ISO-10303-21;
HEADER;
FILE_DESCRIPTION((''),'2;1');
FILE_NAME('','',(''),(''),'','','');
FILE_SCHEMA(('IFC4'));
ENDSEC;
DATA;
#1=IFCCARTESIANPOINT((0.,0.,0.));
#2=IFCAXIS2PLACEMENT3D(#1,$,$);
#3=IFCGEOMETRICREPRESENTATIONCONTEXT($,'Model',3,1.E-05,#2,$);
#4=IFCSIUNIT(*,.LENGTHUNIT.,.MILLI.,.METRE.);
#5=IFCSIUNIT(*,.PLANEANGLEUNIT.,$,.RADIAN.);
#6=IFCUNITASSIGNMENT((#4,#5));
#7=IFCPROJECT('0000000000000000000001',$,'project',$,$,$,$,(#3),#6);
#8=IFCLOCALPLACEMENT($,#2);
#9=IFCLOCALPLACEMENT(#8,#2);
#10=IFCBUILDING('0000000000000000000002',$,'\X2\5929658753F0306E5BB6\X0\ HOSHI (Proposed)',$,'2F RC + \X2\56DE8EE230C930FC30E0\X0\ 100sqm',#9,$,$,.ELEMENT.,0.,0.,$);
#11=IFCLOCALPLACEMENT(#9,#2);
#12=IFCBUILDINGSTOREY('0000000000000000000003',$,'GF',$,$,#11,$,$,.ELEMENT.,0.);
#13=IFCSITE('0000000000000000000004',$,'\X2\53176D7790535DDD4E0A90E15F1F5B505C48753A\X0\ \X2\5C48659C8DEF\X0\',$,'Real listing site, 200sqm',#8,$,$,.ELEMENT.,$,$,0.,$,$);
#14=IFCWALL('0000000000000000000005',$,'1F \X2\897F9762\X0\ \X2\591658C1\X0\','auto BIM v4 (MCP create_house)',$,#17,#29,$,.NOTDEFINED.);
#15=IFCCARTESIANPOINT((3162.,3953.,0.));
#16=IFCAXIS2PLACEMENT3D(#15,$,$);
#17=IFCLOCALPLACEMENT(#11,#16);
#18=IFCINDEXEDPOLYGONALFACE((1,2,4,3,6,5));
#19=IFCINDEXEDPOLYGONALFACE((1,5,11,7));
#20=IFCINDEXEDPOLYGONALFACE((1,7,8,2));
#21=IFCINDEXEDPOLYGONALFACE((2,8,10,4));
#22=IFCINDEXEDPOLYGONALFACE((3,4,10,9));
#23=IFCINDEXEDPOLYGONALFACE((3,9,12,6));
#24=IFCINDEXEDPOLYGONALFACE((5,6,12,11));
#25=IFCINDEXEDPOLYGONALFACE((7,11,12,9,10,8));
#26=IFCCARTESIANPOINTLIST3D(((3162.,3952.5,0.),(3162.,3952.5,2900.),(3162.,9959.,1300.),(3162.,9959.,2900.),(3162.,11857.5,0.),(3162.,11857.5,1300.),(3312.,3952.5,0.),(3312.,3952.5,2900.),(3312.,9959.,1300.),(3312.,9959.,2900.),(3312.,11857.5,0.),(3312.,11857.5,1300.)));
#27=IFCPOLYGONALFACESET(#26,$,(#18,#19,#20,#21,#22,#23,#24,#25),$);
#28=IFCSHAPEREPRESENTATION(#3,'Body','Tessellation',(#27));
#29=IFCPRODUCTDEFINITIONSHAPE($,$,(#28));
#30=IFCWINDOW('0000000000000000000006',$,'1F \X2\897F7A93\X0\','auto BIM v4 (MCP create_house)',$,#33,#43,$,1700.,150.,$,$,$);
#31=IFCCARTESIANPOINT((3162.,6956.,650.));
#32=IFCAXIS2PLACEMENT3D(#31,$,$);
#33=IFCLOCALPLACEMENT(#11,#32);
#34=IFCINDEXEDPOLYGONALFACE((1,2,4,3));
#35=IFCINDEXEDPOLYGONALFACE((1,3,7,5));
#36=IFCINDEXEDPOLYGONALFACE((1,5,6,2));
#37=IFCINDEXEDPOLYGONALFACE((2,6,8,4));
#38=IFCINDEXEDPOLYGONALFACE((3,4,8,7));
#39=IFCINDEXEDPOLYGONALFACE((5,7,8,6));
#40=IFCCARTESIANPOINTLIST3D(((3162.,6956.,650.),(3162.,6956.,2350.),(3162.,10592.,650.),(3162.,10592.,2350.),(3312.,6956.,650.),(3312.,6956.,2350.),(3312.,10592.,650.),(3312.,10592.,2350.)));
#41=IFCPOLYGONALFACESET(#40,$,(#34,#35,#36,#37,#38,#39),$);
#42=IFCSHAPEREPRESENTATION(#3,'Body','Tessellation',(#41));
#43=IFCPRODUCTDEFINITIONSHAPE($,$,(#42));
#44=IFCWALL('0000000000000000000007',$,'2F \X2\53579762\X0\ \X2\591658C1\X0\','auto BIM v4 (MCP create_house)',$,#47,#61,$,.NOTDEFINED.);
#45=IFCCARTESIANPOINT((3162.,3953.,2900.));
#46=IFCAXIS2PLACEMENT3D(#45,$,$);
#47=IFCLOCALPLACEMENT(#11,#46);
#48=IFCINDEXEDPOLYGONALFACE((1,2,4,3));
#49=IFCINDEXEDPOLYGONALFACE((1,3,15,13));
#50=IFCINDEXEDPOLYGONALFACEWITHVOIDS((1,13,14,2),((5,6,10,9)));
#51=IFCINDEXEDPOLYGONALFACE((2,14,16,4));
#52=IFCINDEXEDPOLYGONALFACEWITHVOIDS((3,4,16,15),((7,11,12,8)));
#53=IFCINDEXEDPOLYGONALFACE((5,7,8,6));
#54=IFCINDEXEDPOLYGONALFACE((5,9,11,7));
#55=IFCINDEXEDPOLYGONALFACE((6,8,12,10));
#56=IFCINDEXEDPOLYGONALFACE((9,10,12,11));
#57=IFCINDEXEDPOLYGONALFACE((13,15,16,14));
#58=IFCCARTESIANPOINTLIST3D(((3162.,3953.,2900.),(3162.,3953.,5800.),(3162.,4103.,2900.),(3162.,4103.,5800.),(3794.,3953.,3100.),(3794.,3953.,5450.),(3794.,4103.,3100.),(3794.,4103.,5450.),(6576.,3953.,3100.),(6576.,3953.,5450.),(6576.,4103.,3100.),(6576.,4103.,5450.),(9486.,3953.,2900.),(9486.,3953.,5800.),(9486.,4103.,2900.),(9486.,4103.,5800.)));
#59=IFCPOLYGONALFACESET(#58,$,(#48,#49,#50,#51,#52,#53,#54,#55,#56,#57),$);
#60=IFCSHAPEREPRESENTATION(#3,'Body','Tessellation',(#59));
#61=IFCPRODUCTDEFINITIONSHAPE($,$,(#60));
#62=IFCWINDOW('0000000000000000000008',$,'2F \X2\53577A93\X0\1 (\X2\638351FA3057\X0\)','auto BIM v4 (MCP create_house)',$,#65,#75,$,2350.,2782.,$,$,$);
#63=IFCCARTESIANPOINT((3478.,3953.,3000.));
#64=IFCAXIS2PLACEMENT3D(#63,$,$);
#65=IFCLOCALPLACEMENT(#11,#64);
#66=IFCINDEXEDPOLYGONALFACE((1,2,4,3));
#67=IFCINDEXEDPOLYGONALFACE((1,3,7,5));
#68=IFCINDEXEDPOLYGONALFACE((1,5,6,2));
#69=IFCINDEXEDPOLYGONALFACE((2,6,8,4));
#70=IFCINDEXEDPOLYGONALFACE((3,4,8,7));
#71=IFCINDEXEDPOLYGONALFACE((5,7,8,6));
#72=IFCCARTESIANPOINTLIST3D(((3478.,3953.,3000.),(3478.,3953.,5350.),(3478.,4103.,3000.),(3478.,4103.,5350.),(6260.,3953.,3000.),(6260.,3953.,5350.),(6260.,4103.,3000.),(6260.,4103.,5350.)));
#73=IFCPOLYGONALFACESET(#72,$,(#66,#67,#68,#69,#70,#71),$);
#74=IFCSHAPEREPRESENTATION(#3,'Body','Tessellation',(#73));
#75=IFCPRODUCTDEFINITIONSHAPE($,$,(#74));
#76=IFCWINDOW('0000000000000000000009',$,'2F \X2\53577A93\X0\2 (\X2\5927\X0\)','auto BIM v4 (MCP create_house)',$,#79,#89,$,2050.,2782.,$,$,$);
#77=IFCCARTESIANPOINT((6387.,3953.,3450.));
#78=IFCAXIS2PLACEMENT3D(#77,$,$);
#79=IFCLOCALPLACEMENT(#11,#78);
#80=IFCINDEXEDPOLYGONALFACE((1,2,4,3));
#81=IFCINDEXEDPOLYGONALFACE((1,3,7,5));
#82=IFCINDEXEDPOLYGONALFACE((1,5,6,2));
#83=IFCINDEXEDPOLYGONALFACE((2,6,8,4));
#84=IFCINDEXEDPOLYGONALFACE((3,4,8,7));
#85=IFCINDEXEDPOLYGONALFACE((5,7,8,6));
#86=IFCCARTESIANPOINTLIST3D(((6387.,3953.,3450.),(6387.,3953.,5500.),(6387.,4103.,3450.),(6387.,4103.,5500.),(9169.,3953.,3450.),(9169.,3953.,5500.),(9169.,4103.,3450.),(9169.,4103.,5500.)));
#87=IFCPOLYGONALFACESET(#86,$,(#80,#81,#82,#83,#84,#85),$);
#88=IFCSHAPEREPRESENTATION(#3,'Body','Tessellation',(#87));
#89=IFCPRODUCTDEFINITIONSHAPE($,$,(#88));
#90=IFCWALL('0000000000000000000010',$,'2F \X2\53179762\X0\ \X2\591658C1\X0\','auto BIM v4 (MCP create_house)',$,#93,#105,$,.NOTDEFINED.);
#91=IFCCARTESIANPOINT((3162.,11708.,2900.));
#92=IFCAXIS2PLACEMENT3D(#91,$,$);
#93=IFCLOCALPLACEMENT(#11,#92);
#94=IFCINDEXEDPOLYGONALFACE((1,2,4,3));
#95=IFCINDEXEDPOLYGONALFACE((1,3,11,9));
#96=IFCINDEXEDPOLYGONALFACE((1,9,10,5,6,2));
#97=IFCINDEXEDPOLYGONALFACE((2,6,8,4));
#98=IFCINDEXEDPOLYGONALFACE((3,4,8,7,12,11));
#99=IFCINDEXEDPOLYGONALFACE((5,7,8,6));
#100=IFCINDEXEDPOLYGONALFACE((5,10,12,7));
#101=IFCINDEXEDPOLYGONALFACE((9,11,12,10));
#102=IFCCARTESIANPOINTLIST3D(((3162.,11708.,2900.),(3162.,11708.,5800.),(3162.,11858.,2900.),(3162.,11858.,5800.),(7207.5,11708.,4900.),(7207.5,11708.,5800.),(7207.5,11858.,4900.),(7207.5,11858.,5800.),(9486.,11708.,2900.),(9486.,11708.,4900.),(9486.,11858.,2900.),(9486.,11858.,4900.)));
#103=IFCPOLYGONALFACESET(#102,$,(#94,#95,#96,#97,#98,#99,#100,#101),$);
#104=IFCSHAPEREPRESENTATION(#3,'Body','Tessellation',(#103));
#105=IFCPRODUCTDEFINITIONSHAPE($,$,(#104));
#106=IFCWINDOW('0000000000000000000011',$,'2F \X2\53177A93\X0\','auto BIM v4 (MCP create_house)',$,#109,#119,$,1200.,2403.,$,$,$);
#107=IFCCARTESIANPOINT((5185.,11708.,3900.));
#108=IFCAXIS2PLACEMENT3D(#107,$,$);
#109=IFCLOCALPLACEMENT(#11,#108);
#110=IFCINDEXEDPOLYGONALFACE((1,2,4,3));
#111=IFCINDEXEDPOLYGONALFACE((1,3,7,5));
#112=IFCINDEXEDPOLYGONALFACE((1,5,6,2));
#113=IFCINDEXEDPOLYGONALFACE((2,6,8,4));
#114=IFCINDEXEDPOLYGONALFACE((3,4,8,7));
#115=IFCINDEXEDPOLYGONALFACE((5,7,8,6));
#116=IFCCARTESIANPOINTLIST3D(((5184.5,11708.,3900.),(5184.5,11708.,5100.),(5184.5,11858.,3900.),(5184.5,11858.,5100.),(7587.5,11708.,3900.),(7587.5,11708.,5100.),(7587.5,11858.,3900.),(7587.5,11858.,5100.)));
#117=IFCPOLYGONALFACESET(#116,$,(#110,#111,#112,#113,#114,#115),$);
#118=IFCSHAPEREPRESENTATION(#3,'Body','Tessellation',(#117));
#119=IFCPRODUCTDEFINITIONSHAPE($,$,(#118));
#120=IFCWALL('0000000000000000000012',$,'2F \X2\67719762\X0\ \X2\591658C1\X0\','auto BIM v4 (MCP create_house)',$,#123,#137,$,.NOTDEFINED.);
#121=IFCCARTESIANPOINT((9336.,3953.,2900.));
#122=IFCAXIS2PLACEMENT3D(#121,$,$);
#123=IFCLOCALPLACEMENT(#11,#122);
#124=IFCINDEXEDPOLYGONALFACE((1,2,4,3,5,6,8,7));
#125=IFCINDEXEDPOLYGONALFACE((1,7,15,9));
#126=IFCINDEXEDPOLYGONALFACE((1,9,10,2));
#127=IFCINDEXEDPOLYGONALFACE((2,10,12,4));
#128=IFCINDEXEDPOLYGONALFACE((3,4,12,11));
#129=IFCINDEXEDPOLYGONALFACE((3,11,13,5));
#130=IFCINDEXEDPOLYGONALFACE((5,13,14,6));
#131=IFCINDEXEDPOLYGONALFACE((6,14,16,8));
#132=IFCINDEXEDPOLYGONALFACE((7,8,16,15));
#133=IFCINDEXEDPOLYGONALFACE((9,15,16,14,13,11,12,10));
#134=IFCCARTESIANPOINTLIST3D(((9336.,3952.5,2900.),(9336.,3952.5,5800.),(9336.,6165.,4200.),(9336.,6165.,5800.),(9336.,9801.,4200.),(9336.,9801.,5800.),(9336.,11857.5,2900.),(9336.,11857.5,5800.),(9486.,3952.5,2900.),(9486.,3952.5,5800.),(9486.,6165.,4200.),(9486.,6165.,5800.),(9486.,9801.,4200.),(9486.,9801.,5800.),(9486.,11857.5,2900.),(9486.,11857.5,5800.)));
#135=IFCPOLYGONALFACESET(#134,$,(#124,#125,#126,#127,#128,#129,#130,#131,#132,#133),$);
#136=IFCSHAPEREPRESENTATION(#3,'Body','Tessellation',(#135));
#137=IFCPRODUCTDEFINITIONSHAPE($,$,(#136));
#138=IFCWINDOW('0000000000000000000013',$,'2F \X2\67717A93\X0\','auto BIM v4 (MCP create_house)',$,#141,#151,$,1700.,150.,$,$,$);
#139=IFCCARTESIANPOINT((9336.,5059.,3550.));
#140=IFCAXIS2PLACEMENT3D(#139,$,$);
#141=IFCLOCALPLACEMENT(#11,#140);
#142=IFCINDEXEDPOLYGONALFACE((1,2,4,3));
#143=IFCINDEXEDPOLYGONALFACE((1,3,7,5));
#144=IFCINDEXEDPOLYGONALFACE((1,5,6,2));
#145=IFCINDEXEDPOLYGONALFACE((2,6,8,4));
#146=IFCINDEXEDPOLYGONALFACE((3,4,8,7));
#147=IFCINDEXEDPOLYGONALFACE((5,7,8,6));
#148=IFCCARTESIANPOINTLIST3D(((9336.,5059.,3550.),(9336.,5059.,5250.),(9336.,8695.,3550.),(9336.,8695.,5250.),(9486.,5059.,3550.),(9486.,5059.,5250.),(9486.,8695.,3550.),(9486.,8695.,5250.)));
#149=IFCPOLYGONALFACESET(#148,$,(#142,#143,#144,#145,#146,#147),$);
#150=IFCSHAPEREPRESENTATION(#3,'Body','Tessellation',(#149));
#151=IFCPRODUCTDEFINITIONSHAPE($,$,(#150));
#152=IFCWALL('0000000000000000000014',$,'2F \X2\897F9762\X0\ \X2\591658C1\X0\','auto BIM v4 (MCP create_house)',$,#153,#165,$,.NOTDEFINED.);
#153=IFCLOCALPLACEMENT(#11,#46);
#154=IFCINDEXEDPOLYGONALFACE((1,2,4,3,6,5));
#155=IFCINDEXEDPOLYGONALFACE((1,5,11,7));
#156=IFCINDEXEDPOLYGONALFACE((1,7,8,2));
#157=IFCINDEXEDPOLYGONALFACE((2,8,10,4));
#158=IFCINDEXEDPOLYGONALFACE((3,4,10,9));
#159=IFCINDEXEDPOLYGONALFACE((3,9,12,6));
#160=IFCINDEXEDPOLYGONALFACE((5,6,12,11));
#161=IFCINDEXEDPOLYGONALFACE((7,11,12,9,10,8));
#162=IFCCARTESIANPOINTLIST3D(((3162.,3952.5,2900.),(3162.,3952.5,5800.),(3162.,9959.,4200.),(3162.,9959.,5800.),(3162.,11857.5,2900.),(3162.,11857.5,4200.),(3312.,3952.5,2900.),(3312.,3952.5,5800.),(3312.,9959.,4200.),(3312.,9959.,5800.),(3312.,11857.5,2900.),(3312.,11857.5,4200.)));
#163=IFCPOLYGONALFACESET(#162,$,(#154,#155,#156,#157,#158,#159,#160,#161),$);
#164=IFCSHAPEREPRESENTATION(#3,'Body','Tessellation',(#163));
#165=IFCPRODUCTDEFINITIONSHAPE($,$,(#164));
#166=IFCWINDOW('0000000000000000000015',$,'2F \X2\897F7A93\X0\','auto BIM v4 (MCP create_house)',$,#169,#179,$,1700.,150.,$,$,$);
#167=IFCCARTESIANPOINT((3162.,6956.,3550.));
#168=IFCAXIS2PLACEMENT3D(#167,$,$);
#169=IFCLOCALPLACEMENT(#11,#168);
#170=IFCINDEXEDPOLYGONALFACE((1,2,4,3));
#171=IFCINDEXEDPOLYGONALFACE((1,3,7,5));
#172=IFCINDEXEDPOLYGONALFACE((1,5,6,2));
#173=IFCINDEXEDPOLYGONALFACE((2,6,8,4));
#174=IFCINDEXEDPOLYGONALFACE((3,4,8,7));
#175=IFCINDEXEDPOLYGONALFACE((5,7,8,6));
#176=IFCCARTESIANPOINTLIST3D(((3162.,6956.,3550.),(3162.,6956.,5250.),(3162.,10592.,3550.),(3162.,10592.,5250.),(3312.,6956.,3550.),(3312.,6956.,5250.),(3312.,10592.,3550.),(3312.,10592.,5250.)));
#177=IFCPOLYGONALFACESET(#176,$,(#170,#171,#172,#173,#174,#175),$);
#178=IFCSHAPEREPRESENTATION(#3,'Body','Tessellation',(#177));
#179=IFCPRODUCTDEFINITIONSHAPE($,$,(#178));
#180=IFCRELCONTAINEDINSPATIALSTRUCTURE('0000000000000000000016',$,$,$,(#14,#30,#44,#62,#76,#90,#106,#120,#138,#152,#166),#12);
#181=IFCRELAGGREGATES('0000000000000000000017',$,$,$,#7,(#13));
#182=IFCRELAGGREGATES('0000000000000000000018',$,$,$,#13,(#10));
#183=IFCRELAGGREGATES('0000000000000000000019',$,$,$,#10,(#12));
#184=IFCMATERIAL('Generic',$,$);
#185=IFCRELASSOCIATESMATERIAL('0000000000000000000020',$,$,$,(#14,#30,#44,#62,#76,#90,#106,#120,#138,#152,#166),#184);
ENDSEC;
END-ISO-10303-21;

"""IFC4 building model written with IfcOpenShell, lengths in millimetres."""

from ifc_helpers import new_model, si_unit, frame, frame_2d, origin, place, context, project, spatial, rectangle, extrude, material, element, fill, save


model = new_model("IFC4")

# Units and contexts
model_context = context("Model", 3, precision=1e-05, world=origin())
ifc_project = project(units=[si_unit("LENGTHUNIT", "METRE", prefix="MILLI"), si_unit("PLANEANGLEUNIT", "RADIAN")], contexts=[model_context])

# Site, building, storey
site_placement = place(None, origin())
site = spatial("IfcSite", under=ifc_project, at=site_placement, Name="北海道川上郡弟子屈町 屈斜路", ObjectType="Real listing site, 200sqm", CompositionType="ELEMENT", RefElevation=0.0)
building_placement = place(site_placement, origin())
building = spatial("IfcBuilding", under=site, at=building_placement, Name="天文台の家 HOSHI (Proposed)", ObjectType="2F RC + 回転ドーム 100sqm", CompositionType="ELEMENT", ElevationOfRefHeight=0.0, ElevationOfTerrain=0.0)
storey_placement = place(building_placement, origin())
storey = spatial("IfcBuildingStorey", under=building, at=storey_placement, Name="GF", CompositionType="ELEMENT", Elevation=0.0)

# Shared definitions
ifc_material = material(Name="Generic")

# Wall, opening, window
wall_1_placement = place(storey_placement, frame((3162.0, 3953.0, 0.0)))
wall_1 = element("IfcWall", 1, at=wall_1_placement, inside=storey, material=ifc_material, Name="1F 西面 外壁", Description="auto BIM v4 (MCP create_house)", PredefinedType="NOTDEFINED", context=model_context, shape_type="SweptSolid", body=[
    extrude(rectangle(XDim=150.0, YDim=7905.0, at=frame_2d((75.0, 3952.0))), frame((3162.0, 3953.0, 0.0)), (0.0, 0.0, 1.0), 2900.0),
])
opening_1_placement = place(storey_placement, frame((3162.0, 6956.0, 650.0)))
opening_1 = element("IfcOpeningElement", 2, at=opening_1_placement, cuts=wall_1, PredefinedType="NOTDEFINED", context=model_context, shape_type="SweptSolid", body=[
    extrude(rectangle(XDim=150.0, YDim=3636.0, at=frame_2d((75.0, 1818.0))), frame((3162.0, 6956.0, 650.0)), (0.0, 0.0, 1.0), 1700.0),
])
window_1_placement = place(storey_placement, frame((3162.0, 6956.0, 650.0)))
window_1 = element("IfcWindow", 3, at=window_1_placement, inside=storey, material=ifc_material, Name="1F 西窓", Description="auto BIM v4 (MCP create_house)", OverallHeight=1700.0, OverallWidth=150.0, context=model_context, shape_type="SweptSolid", body=[
    extrude(rectangle(XDim=150.0, YDim=3636.0, at=frame_2d((75.0, 1818.0))), frame((3162.0, 6956.0, 650.0)), (0.0, 0.0, 1.0), 1700.0),
])
fill(opening_1, window_1)

# Wall, openings, windows
wall_2_placement = place(storey_placement, frame((3162.0, 3953.0, 2900.0)))
wall_2 = element("IfcWall", 4, at=wall_2_placement, inside=storey, material=ifc_material, Name="2F 南面 外壁", Description="auto BIM v4 (MCP create_house)", PredefinedType="NOTDEFINED", context=model_context, shape_type="SweptSolid", body=[
    extrude(rectangle(XDim=6324.0, YDim=150.0, at=frame_2d((3162.0, 75.0))), frame((3162.0, 3953.0, 2900.0)), (0.0, 0.0, 1.0), 2900.0),
])
opening_2_placement = place(storey_placement, frame((3478.0, 3953.0, 3000.0)))
opening_2 = element("IfcOpeningElement", 5, at=opening_2_placement, cuts=wall_2, PredefinedType="NOTDEFINED", context=model_context, shape_type="SweptSolid", body=[
    extrude(rectangle(XDim=2782.0, YDim=150.0, at=frame_2d((1391.0, 75.0))), frame((3478.0, 3953.0, 3000.0)), (0.0, 0.0, 1.0), 2350.0),
])
opening_3_placement = place(storey_placement, frame((6387.0, 3953.0, 3450.0)))
opening_3 = element("IfcOpeningElement", 6, at=opening_3_placement, cuts=wall_2, PredefinedType="NOTDEFINED", context=model_context, shape_type="SweptSolid", body=[
    extrude(rectangle(XDim=2782.0, YDim=150.0, at=frame_2d((1391.0, 75.0))), frame((6387.0, 3953.0, 3450.0)), (0.0, 0.0, 1.0), 2050.0),
])
window_2_placement = place(storey_placement, frame((3478.0, 3953.0, 3000.0)))
window_2 = element("IfcWindow", 7, at=window_2_placement, inside=storey, material=ifc_material, Name="2F 南窓1 (掃出し)", Description="auto BIM v4 (MCP create_house)", OverallHeight=2350.0, OverallWidth=2782.0, context=model_context, shape_type="SweptSolid", body=[
    extrude(rectangle(XDim=2782.0, YDim=150.0, at=frame_2d((1391.0, 75.0))), frame((3478.0, 3953.0, 3000.0)), (0.0, 0.0, 1.0), 2350.0),
])
fill(opening_2, window_2)
window_3_placement = place(storey_placement, frame((6387.0, 3953.0, 3450.0)))
window_3 = element("IfcWindow", 8, at=window_3_placement, inside=storey, material=ifc_material, Name="2F 南窓2 (大)", Description="auto BIM v4 (MCP create_house)", OverallHeight=2050.0, OverallWidth=2782.0, context=model_context, shape_type="SweptSolid", body=[
    extrude(rectangle(XDim=2782.0, YDim=150.0, at=frame_2d((1391.0, 75.0))), frame((6387.0, 3953.0, 3450.0)), (0.0, 0.0, 1.0), 2050.0),
])
fill(opening_3, window_3)

# Walls, openings, windows
wall_3_placement = place(storey_placement, frame((3162.0, 11708.0, 2900.0)))
wall_3 = element("IfcWall", 9, at=wall_3_placement, inside=storey, material=ifc_material, Name="2F 北面 外壁", Description="auto BIM v4 (MCP create_house)", PredefinedType="NOTDEFINED", context=model_context, shape_type="SweptSolid", body=[
    extrude(rectangle(XDim=6324.0, YDim=150.0, at=frame_2d((3162.0, 75.0))), frame((3162.0, 11708.0, 2900.0)), (0.0, 0.0, 1.0), 2900.0),
])
opening_4_placement = place(storey_placement, frame((5185.0, 11708.0, 3900.0)))
opening_4 = element("IfcOpeningElement", 10, at=opening_4_placement, cuts=wall_3, PredefinedType="NOTDEFINED", context=model_context, shape_type="SweptSolid", body=[
    extrude(rectangle(XDim=2403.0, YDim=150.0, at=frame_2d((1201.0, 75.0))), frame((5185.0, 11708.0, 3900.0)), (0.0, 0.0, 1.0), 1200.0),
])
window_4_placement = place(storey_placement, frame((5185.0, 11708.0, 3900.0)))
window_4 = element("IfcWindow", 11, at=window_4_placement, inside=storey, material=ifc_material, Name="2F 北窓", Description="auto BIM v4 (MCP create_house)", OverallHeight=1200.0, OverallWidth=2403.0, context=model_context, shape_type="SweptSolid", body=[
    extrude(rectangle(XDim=2403.0, YDim=150.0, at=frame_2d((1201.0, 75.0))), frame((5185.0, 11708.0, 3900.0)), (0.0, 0.0, 1.0), 1200.0),
])
fill(opening_4, window_4)
wall_4_placement = place(storey_placement, frame((9336.0, 3953.0, 2900.0)))
wall_4 = element("IfcWall", 12, at=wall_4_placement, inside=storey, material=ifc_material, Name="2F 東面 外壁", Description="auto BIM v4 (MCP create_house)", PredefinedType="NOTDEFINED", context=model_context, shape_type="SweptSolid", body=[
    extrude(rectangle(XDim=150.0, YDim=7905.0, at=frame_2d((75.0, 3952.0))), frame((9336.0, 3953.0, 2900.0)), (0.0, 0.0, 1.0), 2900.0),
])
opening_5_placement = place(storey_placement, frame((9336.0, 5059.0, 3550.0)))
opening_5 = element("IfcOpeningElement", 13, at=opening_5_placement, cuts=wall_4, PredefinedType="NOTDEFINED", context=model_context, shape_type="SweptSolid", body=[
    extrude(rectangle(XDim=150.0, YDim=3636.0, at=frame_2d((75.0, 1818.0))), frame((9336.0, 5059.0, 3550.0)), (0.0, 0.0, 1.0), 1700.0),
])
window_5_placement = place(storey_placement, frame((9336.0, 5059.0, 3550.0)))
window_5 = element("IfcWindow", 14, at=window_5_placement, inside=storey, material=ifc_material, Name="2F 東窓", Description="auto BIM v4 (MCP create_house)", OverallHeight=1700.0, OverallWidth=150.0, context=model_context, shape_type="SweptSolid", body=[
    extrude(rectangle(XDim=150.0, YDim=3636.0, at=frame_2d((75.0, 1818.0))), frame((9336.0, 5059.0, 3550.0)), (0.0, 0.0, 1.0), 1700.0),
])
fill(opening_5, window_5)
wall_5_placement = place(storey_placement, frame((3162.0, 3953.0, 2900.0)))
wall_5 = element("IfcWall", 15, at=wall_5_placement, inside=storey, material=ifc_material, Name="2F 西面 外壁", Description="auto BIM v4 (MCP create_house)", PredefinedType="NOTDEFINED", context=model_context, shape_type="SweptSolid", body=[
    extrude(rectangle(XDim=150.0, YDim=7905.0, at=frame_2d((75.0, 3952.0))), frame((3162.0, 3953.0, 2900.0)), (0.0, 0.0, 1.0), 2900.0),
])
opening_6_placement = place(storey_placement, frame((3162.0, 6956.0, 3550.0)))
opening_6 = element("IfcOpeningElement", 16, at=opening_6_placement, cuts=wall_5, PredefinedType="NOTDEFINED", context=model_context, shape_type="SweptSolid", body=[
    extrude(rectangle(XDim=150.0, YDim=3636.0, at=frame_2d((75.0, 1818.0))), frame((3162.0, 6956.0, 3550.0)), (0.0, 0.0, 1.0), 1700.0),
])
window_6_placement = place(storey_placement, frame((3162.0, 6956.0, 3550.0)))
window_6 = element("IfcWindow", 17, at=window_6_placement, inside=storey, material=ifc_material, Name="2F 西窓", Description="auto BIM v4 (MCP create_house)", OverallHeight=1700.0, OverallWidth=150.0, context=model_context, shape_type="SweptSolid", body=[
    extrude(rectangle(XDim=150.0, YDim=3636.0, at=frame_2d((75.0, 1818.0))), frame((3162.0, 6956.0, 3550.0)), (0.0, 0.0, 1.0), 1700.0),
])
fill(opening_6, window_6)

save(model, "model.ifc")
